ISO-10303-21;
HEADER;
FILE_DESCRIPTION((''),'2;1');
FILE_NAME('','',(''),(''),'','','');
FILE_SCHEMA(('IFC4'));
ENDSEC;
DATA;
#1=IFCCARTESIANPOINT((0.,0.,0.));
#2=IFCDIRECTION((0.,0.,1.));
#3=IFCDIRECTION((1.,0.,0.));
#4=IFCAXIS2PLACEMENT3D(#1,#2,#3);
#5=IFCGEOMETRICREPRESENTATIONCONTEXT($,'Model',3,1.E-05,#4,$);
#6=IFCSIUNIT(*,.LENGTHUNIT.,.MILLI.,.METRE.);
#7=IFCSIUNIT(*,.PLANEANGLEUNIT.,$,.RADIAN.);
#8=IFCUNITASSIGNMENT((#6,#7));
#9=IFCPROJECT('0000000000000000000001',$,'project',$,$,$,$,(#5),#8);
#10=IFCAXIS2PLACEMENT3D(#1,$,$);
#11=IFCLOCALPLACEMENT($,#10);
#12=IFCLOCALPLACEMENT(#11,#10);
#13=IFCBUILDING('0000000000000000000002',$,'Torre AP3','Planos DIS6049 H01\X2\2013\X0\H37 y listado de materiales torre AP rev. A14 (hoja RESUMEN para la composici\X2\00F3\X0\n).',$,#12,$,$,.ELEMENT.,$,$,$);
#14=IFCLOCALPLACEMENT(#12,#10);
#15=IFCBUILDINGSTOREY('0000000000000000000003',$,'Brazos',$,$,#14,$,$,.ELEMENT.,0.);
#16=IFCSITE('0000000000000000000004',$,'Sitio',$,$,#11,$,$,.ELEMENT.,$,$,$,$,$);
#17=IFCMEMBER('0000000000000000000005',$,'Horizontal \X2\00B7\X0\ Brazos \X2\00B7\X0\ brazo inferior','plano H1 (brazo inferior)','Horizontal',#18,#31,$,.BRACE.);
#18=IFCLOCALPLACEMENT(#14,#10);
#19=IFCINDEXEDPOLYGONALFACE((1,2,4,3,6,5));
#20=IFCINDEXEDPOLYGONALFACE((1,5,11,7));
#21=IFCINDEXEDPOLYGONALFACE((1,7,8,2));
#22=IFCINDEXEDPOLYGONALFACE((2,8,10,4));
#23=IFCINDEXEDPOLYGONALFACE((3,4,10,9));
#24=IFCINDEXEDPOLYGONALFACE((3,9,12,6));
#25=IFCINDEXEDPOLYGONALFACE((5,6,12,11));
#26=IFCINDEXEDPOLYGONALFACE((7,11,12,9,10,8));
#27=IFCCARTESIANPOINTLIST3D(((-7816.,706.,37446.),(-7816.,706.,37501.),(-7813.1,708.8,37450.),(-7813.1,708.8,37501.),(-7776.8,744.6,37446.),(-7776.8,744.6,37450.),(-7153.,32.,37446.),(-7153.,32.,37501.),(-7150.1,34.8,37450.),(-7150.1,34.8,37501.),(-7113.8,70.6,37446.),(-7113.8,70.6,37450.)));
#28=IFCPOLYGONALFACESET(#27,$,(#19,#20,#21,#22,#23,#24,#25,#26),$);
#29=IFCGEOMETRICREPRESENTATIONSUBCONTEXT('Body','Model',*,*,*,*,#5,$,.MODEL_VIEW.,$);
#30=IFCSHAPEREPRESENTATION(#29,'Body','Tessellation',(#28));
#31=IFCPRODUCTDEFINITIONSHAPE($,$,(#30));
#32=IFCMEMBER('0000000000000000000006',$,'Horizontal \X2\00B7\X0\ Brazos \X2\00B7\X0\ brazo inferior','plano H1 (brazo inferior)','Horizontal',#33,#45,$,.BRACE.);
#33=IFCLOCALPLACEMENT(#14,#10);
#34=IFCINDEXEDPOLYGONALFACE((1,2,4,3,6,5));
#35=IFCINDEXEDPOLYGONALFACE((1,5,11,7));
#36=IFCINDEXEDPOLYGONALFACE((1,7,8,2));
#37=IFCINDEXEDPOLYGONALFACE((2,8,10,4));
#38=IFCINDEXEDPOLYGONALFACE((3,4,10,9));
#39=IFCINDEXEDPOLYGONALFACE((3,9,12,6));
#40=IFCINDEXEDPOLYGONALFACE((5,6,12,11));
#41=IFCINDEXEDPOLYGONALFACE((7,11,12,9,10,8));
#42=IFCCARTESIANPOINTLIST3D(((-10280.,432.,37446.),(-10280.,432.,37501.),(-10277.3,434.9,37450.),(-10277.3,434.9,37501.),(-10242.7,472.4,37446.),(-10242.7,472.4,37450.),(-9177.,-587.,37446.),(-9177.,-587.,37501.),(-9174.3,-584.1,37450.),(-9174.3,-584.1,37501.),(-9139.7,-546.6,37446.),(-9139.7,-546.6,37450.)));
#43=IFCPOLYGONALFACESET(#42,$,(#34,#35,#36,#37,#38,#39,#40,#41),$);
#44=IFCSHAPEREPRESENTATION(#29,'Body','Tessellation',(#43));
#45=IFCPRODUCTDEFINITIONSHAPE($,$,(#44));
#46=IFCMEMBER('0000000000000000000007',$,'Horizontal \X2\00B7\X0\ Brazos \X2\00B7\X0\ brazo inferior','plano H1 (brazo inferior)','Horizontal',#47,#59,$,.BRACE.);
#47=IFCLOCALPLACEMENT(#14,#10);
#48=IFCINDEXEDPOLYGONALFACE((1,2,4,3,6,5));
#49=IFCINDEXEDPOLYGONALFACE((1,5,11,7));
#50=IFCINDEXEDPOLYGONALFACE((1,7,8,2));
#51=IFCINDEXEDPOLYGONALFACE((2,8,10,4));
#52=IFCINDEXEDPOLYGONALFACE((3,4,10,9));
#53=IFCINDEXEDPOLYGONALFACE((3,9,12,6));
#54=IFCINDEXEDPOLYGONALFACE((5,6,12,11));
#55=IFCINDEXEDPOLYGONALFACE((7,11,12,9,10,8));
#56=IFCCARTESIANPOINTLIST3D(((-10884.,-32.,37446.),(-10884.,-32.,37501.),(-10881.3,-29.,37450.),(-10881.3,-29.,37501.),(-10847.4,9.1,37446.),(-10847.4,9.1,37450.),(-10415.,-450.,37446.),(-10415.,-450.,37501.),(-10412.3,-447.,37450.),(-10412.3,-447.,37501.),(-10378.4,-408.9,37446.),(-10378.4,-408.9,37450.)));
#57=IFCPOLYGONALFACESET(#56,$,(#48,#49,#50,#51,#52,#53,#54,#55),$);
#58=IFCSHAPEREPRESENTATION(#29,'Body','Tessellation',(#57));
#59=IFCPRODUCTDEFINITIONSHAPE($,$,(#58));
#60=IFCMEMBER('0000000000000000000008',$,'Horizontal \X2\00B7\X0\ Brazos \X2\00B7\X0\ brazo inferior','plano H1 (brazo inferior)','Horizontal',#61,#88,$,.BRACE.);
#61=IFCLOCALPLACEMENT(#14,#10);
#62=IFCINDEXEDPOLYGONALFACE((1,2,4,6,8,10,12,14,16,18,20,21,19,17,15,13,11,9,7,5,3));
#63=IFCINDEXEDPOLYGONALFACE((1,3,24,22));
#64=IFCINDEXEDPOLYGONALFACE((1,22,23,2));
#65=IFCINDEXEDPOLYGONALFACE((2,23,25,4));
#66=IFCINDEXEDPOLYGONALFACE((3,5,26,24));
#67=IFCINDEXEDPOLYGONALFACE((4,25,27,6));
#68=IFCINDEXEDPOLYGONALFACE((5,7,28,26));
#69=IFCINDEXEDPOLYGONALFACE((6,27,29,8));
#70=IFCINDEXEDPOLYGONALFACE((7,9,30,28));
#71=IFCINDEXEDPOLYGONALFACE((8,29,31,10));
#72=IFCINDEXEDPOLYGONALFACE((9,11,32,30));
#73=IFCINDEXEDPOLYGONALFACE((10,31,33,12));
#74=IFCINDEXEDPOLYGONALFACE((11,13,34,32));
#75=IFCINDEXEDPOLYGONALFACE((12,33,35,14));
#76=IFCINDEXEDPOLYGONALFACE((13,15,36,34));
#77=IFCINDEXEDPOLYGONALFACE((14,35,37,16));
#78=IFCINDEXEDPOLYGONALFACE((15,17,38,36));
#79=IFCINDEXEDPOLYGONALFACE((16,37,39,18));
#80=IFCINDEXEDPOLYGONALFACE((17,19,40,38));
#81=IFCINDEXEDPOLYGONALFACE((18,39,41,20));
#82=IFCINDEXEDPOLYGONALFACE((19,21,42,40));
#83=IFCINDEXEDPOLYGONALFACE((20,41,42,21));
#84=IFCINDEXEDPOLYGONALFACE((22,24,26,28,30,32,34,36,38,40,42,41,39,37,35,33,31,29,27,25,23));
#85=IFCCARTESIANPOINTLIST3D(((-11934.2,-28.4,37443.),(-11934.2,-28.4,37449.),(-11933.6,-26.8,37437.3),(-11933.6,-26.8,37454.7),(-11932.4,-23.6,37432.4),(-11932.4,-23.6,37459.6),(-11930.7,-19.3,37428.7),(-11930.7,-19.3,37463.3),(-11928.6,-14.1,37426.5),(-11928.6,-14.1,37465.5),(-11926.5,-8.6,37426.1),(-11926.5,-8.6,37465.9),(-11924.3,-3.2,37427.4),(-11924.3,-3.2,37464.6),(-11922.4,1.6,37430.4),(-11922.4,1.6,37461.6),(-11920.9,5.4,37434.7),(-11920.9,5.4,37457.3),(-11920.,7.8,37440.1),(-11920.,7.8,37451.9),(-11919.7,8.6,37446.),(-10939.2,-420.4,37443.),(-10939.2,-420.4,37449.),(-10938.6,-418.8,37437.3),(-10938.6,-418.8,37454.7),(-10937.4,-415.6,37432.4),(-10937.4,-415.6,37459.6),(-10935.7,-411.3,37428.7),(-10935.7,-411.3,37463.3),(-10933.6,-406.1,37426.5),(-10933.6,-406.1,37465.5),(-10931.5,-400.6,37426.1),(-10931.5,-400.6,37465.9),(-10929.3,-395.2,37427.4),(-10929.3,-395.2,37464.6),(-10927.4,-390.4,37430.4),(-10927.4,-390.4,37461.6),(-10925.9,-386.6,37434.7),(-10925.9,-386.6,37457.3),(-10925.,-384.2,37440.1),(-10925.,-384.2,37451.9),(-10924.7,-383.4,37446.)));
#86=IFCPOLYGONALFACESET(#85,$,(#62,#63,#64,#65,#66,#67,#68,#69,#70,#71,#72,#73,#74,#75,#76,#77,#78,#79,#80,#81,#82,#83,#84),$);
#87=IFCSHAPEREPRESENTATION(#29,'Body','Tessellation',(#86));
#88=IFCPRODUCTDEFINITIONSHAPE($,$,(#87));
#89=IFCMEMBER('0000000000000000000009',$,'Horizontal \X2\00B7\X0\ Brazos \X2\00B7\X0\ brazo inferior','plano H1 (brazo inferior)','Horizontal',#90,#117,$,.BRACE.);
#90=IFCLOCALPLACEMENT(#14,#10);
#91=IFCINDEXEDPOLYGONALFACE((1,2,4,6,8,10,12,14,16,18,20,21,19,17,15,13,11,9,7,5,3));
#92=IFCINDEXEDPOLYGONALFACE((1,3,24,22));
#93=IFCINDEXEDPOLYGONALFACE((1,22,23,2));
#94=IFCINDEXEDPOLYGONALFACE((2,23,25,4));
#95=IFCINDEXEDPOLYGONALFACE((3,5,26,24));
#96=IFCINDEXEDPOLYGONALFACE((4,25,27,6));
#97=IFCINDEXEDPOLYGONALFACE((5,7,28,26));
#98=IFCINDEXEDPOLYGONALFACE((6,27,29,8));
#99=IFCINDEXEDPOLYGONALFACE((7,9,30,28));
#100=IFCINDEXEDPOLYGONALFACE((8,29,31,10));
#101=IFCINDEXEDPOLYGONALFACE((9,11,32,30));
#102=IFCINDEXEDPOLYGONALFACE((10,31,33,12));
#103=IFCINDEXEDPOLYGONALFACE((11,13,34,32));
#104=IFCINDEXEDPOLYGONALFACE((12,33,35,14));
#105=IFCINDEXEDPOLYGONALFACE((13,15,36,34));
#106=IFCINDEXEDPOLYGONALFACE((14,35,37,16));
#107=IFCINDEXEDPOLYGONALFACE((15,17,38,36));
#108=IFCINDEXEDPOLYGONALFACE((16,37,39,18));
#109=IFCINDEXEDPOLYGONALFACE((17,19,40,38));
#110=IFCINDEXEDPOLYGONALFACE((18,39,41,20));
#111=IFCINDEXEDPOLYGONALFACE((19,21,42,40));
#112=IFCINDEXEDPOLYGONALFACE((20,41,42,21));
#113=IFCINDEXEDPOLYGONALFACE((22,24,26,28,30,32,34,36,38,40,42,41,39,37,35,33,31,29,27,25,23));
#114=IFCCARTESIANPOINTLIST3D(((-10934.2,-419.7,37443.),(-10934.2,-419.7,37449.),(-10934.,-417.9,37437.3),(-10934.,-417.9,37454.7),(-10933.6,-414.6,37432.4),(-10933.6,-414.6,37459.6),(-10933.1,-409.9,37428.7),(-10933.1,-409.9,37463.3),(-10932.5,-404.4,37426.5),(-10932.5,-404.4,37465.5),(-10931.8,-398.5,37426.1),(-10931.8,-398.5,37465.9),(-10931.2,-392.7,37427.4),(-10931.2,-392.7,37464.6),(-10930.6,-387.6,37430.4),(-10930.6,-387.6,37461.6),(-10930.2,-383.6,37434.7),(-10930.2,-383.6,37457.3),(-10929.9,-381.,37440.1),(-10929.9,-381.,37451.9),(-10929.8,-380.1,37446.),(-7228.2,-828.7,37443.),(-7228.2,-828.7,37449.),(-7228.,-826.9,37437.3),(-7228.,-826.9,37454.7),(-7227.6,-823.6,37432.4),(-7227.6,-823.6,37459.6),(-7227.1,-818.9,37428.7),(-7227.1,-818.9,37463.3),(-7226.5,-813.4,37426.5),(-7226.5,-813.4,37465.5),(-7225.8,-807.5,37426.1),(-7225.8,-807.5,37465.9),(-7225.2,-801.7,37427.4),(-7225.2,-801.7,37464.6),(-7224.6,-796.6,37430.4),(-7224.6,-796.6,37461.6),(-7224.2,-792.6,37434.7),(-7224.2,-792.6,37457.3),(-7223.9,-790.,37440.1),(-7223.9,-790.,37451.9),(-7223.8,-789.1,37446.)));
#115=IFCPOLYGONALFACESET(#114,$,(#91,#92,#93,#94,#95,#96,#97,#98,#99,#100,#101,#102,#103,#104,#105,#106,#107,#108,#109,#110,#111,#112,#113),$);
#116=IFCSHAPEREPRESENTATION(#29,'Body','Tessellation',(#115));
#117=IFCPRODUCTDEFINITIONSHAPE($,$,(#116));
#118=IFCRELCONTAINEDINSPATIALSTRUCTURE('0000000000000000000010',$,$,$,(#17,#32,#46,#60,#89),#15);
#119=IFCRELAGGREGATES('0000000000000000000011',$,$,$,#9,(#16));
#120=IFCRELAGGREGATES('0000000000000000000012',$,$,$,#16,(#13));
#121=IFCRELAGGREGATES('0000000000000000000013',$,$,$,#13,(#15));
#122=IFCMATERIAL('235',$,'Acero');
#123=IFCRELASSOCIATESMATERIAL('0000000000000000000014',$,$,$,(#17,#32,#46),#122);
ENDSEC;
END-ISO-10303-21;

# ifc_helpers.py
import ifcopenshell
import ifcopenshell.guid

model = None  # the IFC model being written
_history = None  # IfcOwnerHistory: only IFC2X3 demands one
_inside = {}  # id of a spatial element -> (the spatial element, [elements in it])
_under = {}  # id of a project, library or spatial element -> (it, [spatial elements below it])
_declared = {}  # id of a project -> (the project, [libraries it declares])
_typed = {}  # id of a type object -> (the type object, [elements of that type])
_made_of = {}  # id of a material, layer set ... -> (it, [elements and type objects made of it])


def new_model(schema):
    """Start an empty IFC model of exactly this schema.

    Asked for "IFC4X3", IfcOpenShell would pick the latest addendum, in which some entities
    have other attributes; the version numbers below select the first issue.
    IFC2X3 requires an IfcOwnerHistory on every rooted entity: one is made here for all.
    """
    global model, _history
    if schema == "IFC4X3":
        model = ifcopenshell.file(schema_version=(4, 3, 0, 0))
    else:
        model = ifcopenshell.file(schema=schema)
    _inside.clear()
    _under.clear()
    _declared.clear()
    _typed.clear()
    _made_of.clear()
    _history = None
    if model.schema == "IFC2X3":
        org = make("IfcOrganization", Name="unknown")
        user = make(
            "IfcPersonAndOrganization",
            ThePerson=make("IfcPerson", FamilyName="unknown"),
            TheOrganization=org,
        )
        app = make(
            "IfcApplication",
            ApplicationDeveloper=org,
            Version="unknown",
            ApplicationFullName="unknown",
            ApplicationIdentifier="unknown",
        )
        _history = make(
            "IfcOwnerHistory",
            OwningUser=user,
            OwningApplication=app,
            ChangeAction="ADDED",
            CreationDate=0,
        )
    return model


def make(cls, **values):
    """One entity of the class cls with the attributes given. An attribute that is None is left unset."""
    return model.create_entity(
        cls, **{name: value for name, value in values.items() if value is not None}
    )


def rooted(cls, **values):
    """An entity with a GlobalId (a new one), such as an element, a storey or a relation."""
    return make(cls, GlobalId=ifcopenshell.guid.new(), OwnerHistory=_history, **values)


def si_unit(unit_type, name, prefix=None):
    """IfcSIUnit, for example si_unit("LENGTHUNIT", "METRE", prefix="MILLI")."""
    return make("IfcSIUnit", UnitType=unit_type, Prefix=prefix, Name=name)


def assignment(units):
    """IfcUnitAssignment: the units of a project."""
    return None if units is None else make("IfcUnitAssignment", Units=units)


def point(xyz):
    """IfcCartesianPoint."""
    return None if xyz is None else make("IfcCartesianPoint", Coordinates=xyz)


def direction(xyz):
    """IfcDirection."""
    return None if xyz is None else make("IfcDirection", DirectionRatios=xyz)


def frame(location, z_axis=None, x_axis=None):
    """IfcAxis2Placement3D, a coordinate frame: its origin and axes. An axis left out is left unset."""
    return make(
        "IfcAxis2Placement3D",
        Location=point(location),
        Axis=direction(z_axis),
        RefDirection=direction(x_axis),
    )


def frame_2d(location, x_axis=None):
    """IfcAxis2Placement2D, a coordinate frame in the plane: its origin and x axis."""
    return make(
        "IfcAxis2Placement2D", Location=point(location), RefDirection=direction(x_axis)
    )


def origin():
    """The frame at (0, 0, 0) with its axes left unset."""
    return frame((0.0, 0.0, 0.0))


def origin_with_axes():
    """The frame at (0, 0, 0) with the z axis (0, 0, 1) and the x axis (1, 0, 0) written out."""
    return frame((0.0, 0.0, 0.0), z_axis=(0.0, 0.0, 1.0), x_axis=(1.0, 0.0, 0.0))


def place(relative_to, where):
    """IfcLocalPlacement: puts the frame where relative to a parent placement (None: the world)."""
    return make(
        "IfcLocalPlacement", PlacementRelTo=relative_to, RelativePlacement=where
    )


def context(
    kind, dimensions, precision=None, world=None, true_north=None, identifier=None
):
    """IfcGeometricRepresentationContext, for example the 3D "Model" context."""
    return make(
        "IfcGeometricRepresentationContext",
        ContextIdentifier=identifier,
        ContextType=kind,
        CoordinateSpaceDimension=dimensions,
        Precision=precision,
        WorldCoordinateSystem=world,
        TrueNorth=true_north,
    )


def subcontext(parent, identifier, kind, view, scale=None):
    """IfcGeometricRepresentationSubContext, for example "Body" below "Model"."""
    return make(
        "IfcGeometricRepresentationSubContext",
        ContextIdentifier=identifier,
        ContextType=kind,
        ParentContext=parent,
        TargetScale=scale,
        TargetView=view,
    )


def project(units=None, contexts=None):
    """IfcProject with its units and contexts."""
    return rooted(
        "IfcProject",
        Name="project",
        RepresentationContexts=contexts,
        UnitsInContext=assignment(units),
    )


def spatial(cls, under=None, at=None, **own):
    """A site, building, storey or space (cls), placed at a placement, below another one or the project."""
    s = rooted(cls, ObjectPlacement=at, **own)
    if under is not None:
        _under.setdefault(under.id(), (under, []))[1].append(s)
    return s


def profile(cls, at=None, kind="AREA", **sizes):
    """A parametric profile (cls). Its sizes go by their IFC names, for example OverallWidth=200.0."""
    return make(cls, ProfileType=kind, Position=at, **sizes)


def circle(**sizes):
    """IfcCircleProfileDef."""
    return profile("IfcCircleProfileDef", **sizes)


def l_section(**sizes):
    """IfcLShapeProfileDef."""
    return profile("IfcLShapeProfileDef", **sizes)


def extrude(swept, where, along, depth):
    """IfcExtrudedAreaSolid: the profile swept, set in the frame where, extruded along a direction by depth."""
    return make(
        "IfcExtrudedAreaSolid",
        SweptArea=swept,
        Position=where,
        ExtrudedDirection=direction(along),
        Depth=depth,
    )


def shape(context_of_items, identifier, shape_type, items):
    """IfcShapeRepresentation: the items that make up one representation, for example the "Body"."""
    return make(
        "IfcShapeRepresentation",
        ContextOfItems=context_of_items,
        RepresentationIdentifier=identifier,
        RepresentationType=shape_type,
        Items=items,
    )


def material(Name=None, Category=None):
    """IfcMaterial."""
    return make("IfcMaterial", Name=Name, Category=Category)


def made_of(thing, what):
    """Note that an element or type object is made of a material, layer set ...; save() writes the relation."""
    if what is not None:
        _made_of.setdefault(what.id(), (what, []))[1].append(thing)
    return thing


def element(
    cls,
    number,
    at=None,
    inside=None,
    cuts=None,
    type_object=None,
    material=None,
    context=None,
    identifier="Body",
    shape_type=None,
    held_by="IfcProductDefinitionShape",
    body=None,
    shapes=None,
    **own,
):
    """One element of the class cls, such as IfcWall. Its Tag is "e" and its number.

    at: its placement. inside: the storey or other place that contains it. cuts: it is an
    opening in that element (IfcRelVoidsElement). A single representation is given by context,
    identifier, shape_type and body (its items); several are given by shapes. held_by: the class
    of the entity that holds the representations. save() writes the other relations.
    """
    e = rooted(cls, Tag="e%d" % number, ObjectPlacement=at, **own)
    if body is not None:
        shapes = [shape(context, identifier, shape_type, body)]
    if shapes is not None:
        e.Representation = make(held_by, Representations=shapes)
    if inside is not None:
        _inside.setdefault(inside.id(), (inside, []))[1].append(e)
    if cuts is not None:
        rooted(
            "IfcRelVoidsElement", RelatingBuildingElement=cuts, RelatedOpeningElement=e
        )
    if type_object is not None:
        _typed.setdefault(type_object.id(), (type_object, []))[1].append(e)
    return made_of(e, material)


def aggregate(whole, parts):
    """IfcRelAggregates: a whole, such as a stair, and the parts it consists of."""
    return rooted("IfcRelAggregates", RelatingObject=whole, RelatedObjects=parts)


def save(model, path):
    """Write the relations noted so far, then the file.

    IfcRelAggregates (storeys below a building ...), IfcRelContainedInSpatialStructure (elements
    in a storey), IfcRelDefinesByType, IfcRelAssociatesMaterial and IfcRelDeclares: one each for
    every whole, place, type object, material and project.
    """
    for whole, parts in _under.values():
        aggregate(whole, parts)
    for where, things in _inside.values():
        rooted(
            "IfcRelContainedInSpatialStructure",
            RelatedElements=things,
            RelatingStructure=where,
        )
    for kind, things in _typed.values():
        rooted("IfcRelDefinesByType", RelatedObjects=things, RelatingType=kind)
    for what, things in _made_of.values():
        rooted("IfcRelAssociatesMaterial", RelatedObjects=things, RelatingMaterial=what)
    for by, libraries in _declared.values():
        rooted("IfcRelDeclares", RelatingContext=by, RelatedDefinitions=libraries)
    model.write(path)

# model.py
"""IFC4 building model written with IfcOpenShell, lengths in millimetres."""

from ifc_helpers import new_model, si_unit, frame, frame_2d, origin, origin_with_axes, place, context, subcontext, project, spatial, circle, l_section, extrude, material, element, save


model = new_model("IFC4")

# Units and contexts
model_context = context("Model", 3, precision=1e-05, world=origin_with_axes())
body_context = subcontext(model_context, "Body", "Model", "MODEL_VIEW")
ifc_project = project(units=[si_unit("LENGTHUNIT", "METRE", prefix="MILLI"), si_unit("PLANEANGLEUNIT", "RADIAN")], contexts=[model_context])

# Site, building, storey
site_placement = place(None, origin())
site = spatial("IfcSite", under=ifc_project, at=site_placement, Name="Sitio", CompositionType="ELEMENT")
building_placement = place(site_placement, origin())
building = spatial("IfcBuilding", under=site, at=building_placement, Name="Torre AP3", Description="Planos DIS6049 H01–H37 y listado de materiales torre AP rev. A14 (hoja RESUMEN para la composición).", CompositionType="ELEMENT")
storey_placement = place(building_placement, origin())
storey = spatial("IfcBuildingStorey", under=building, at=storey_placement, Name="Brazos", CompositionType="ELEMENT", Elevation=0.0)

# Members
ifc_material_1 = material(Name="235", Category="Acero")
member_1_placement = place(storey_placement, frame((-7816.0, 706.0, 37446.0), z_axis=(0.701265, -0.7129, 0.0), x_axis=(0.7129, 0.701265, 0.0)))
element("IfcMember", 1, at=member_1_placement, inside=storey, material=ifc_material_1, Name="Horizontal · Brazos · brazo inferior", Description="plano H1 (brazo inferior)", ObjectType="Horizontal", PredefinedType="BRACE", context=body_context, shape_type="SweptSolid", body=[
    extrude(l_section(Depth=55.0, Width=55.0, Thickness=4.0, at=frame_2d((27.5, 27.5))), None, (0.0, 0.0, 1.0), 945.4),
])
member_2_placement = place(storey_placement, frame((-10280.0, 432.0, 37446.0), z_axis=(0.734523, -0.678584, 0.0), x_axis=(0.678584, 0.734523, 0.0)))
element("IfcMember", 2, at=member_2_placement, inside=storey, material=ifc_material_1, Name="Horizontal · Brazos · brazo inferior", Description="plano H1 (brazo inferior)", ObjectType="Horizontal", PredefinedType="BRACE", context=body_context, shape_type="SweptSolid", body=[
    extrude(l_section(Depth=55.0, Width=55.0, Thickness=4.0, at=frame_2d((27.5, 27.5))), None, (0.0, 0.0, 1.0), 1501.7),
])
member_3_placement = place(storey_placement, frame((-10884.0, -32.0, 37446.0), z_axis=(0.74653, -0.665351, 0.0), x_axis=(0.665351, 0.74653, 0.0)))
element("IfcMember", 3, at=member_3_placement, inside=storey, material=ifc_material_1, Name="Horizontal · Brazos · brazo inferior", Description="plano H1 (brazo inferior)", ObjectType="Horizontal", PredefinedType="BRACE", context=body_context, shape_type="SweptSolid", body=[
    extrude(l_section(Depth=55.0, Width=55.0, Thickness=4.0, at=frame_2d((27.5, 27.5))), None, (0.0, 0.0, 1.0), 628.2),
])
member_4_placement = place(storey_placement, frame((-11927.0, -10.0, 37446.0), z_axis=(0.930399, -0.366549, 0.0), x_axis=(0.366549, 0.930399, 0.0)))
element("IfcMember", 4, at=member_4_placement, inside=storey, Name="Horizontal · Brazos · brazo inferior", Description="plano H1 (brazo inferior)", ObjectType="Horizontal", PredefinedType="BRACE", context=body_context, shape_type="SweptSolid", body=[
    extrude(circle(Radius=20.0), None, (0.0, 0.0, 1.0), 1069.4),
])
member_5_placement = place(storey_placement, frame((-10932.0, -400.0, 37446.0), z_axis=(0.993965, -0.109696, 0.0), x_axis=(0.109696, 0.993965, 0.0)))
element("IfcMember", 5, at=member_5_placement, inside=storey, Name="Horizontal · Brazos · brazo inferior", Description="plano H1 (brazo inferior)", ObjectType="Horizontal", PredefinedType="BRACE", context=body_context, shape_type="SweptSolid", body=[
    extrude(circle(Radius=20.0), None, (0.0, 0.0, 1.0), 3728.5),
])

save(model, "model.ifc")
